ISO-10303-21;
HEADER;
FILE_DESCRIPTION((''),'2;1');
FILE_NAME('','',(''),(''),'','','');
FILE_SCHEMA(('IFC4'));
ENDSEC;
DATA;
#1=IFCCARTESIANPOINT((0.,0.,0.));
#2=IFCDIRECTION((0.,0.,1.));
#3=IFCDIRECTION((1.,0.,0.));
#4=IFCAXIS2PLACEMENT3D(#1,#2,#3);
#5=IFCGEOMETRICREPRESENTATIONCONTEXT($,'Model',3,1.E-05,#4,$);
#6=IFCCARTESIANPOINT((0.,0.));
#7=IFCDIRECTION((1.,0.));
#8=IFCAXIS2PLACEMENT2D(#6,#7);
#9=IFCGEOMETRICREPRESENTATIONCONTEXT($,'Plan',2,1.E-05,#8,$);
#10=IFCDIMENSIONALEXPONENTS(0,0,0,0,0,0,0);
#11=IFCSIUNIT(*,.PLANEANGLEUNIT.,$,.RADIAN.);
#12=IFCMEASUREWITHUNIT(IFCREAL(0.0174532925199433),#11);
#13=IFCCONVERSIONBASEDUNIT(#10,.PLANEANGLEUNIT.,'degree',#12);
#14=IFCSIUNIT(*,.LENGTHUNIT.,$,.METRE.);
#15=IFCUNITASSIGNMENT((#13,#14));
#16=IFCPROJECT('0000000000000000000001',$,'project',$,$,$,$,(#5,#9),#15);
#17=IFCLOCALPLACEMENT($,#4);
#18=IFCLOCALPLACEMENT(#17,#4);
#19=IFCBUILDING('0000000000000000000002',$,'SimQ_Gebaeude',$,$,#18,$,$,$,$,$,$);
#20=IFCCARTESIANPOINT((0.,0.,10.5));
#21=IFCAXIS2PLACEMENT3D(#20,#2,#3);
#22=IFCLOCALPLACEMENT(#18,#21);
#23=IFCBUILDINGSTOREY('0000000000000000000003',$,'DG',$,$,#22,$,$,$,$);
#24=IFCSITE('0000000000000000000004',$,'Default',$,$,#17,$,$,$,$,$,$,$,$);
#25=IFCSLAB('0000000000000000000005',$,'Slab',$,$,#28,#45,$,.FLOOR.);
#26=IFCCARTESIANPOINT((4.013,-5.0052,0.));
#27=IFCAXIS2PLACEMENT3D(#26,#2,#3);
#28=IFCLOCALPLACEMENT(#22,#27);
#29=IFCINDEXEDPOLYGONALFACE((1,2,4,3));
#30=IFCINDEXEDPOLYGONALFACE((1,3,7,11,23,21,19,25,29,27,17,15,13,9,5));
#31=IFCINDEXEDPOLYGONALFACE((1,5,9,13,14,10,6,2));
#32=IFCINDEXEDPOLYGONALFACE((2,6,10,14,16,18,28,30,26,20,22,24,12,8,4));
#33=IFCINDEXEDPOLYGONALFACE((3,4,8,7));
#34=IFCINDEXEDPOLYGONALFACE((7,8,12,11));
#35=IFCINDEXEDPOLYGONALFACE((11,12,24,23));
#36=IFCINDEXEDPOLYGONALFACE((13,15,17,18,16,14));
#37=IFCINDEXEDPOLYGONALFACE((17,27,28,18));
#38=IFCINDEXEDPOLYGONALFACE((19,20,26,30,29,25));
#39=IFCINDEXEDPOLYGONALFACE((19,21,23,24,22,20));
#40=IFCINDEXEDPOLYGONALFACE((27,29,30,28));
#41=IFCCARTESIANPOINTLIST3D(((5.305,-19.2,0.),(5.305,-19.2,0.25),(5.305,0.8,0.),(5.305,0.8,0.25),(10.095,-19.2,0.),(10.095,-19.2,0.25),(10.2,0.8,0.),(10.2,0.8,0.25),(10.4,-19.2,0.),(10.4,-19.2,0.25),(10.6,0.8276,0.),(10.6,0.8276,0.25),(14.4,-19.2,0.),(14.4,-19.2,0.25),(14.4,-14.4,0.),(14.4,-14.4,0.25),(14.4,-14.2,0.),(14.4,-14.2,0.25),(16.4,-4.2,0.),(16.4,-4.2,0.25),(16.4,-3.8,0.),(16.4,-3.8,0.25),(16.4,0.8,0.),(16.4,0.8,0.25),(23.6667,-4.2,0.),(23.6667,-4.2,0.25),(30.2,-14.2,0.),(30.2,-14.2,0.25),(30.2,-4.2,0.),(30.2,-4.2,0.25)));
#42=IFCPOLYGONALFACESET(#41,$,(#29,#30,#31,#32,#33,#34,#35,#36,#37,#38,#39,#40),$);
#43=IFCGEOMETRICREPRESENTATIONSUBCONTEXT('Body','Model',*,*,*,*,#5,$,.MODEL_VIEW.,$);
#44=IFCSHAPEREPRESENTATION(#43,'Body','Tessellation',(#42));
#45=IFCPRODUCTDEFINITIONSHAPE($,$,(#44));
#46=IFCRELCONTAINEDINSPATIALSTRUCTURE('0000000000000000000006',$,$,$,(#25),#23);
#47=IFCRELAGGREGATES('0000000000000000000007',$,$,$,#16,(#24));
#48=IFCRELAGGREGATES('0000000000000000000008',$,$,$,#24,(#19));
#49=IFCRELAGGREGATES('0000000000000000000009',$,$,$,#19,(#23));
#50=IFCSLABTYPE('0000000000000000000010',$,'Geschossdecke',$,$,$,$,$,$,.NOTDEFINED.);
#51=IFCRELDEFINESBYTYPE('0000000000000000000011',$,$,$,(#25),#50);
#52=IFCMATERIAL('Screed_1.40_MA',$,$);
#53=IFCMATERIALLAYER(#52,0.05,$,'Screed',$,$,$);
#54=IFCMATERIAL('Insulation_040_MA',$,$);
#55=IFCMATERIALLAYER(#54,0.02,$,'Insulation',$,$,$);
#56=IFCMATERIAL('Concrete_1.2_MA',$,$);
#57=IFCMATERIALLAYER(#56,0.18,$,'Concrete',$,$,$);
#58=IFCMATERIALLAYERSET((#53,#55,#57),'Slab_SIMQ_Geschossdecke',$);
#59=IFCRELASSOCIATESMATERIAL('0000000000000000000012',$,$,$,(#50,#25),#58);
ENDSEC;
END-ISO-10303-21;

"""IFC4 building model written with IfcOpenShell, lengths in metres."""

from ifc_helpers import new_model, entity, si_unit, converted_unit, frame, origin_with_axes, origin_2d_with_axis, place, context, subcontext, project, spatial, line, indexed_curve, outline, extrude, material, layer, layer_set, layer_usage, type_object, element, save


model = new_model("IFC4")

# Units and contexts
model_context = context("Model", 3, precision=1e-05, world=origin_with_axes())
plan_context = context("Plan", 2, precision=1e-05, world=origin_2d_with_axis())
body_context = subcontext(model_context, "Body", "Model", "MODEL_VIEW")
ifc_project = project(units=[converted_unit("PLANEANGLEUNIT", "degree", entity("IfcReal", 0.0174532925199433), si_unit("PLANEANGLEUNIT", "RADIAN"), dimensions=[0, 0, 0, 0, 0, 0, 0]), si_unit("LENGTHUNIT", "METRE")], contexts=[model_context, plan_context])

# Site, building, storey
site_placement = place(None, origin_with_axes())
site = spatial("IfcSite", under=ifc_project, at=site_placement, Name="Default")
building_placement = place(site_placement, origin_with_axes())
building = spatial("IfcBuilding", under=site, at=building_placement, Name="SimQ_Gebaeude")
storey_placement = place(building_placement, frame((0.0, 0.0, 10.5), z_axis=(0.0, 0.0, 1.0), x_axis=(1.0, 0.0, 0.0)))
storey = spatial("IfcBuildingStorey", under=building, at=storey_placement, Name="DG")

# Slab
ifc_material_1 = material(Name="Screed_1.40_MA")
ifc_layer_1 = layer(ifc_material_1, 0.05, Name="Screed")
ifc_material_2 = material(Name="Insulation_040_MA")
ifc_layer_2 = layer(ifc_material_2, 0.02, Name="Insulation")
ifc_material_3 = material(Name="Concrete_1.2_MA")
ifc_layer_3 = layer(ifc_material_3, 0.18, Name="Concrete")
ifc_layer_set_1 = layer_set([ifc_layer_1, ifc_layer_2, ifc_layer_3], Name="Slab_SIMQ_Geschossdecke")
ifc_layer_usage_1 = layer_usage(ifc_layer_set_1, "AXIS3", "POSITIVE", 0.0)
slab_type = type_object("IfcSlabType", Name="Geschossdecke", PredefinedType="NOTDEFINED", material=ifc_layer_set_1)
slab_placement = place(storey_placement, frame((4.013, -5.0052, 0.0), z_axis=(0.0, 0.0, 1.0), x_axis=(1.0, 0.0, 0.0)))
element("IfcSlab", 1, at=slab_placement, inside=storey, type_object=slab_type, material=ifc_layer_usage_1, Name="Slab", PredefinedType="FLOOR", context=body_context, shape_type="SweptSolid", body=[
    extrude(outline(indexed_curve([(10.6, 0.8276), (16.4, 0.8), (16.4, -3.8), (16.4, -4.2), (23.6667, -4.2), (30.2, -4.2), (30.2, -14.2), (14.4, -14.2), (14.4, -14.4), (14.4, -19.2), (10.4, -19.2), (10.095, -19.2), (5.305, -19.2), (5.305, 0.8), (10.2, 0.8)], segments=[line(8, 7), line(7, 6), line(6, 5), line(5, 4), line(4, 3), line(3, 2), line(2, 1), line(1, 15), line(15, 14), line(14, 13), line(13, 12), line(12, 11), line(11, 10), line(10, 9), line(9, 8)], self_intersect=False)), None, (0.0, 0.0, 1.0), 0.25),
])

save(model, "model.ifc")
